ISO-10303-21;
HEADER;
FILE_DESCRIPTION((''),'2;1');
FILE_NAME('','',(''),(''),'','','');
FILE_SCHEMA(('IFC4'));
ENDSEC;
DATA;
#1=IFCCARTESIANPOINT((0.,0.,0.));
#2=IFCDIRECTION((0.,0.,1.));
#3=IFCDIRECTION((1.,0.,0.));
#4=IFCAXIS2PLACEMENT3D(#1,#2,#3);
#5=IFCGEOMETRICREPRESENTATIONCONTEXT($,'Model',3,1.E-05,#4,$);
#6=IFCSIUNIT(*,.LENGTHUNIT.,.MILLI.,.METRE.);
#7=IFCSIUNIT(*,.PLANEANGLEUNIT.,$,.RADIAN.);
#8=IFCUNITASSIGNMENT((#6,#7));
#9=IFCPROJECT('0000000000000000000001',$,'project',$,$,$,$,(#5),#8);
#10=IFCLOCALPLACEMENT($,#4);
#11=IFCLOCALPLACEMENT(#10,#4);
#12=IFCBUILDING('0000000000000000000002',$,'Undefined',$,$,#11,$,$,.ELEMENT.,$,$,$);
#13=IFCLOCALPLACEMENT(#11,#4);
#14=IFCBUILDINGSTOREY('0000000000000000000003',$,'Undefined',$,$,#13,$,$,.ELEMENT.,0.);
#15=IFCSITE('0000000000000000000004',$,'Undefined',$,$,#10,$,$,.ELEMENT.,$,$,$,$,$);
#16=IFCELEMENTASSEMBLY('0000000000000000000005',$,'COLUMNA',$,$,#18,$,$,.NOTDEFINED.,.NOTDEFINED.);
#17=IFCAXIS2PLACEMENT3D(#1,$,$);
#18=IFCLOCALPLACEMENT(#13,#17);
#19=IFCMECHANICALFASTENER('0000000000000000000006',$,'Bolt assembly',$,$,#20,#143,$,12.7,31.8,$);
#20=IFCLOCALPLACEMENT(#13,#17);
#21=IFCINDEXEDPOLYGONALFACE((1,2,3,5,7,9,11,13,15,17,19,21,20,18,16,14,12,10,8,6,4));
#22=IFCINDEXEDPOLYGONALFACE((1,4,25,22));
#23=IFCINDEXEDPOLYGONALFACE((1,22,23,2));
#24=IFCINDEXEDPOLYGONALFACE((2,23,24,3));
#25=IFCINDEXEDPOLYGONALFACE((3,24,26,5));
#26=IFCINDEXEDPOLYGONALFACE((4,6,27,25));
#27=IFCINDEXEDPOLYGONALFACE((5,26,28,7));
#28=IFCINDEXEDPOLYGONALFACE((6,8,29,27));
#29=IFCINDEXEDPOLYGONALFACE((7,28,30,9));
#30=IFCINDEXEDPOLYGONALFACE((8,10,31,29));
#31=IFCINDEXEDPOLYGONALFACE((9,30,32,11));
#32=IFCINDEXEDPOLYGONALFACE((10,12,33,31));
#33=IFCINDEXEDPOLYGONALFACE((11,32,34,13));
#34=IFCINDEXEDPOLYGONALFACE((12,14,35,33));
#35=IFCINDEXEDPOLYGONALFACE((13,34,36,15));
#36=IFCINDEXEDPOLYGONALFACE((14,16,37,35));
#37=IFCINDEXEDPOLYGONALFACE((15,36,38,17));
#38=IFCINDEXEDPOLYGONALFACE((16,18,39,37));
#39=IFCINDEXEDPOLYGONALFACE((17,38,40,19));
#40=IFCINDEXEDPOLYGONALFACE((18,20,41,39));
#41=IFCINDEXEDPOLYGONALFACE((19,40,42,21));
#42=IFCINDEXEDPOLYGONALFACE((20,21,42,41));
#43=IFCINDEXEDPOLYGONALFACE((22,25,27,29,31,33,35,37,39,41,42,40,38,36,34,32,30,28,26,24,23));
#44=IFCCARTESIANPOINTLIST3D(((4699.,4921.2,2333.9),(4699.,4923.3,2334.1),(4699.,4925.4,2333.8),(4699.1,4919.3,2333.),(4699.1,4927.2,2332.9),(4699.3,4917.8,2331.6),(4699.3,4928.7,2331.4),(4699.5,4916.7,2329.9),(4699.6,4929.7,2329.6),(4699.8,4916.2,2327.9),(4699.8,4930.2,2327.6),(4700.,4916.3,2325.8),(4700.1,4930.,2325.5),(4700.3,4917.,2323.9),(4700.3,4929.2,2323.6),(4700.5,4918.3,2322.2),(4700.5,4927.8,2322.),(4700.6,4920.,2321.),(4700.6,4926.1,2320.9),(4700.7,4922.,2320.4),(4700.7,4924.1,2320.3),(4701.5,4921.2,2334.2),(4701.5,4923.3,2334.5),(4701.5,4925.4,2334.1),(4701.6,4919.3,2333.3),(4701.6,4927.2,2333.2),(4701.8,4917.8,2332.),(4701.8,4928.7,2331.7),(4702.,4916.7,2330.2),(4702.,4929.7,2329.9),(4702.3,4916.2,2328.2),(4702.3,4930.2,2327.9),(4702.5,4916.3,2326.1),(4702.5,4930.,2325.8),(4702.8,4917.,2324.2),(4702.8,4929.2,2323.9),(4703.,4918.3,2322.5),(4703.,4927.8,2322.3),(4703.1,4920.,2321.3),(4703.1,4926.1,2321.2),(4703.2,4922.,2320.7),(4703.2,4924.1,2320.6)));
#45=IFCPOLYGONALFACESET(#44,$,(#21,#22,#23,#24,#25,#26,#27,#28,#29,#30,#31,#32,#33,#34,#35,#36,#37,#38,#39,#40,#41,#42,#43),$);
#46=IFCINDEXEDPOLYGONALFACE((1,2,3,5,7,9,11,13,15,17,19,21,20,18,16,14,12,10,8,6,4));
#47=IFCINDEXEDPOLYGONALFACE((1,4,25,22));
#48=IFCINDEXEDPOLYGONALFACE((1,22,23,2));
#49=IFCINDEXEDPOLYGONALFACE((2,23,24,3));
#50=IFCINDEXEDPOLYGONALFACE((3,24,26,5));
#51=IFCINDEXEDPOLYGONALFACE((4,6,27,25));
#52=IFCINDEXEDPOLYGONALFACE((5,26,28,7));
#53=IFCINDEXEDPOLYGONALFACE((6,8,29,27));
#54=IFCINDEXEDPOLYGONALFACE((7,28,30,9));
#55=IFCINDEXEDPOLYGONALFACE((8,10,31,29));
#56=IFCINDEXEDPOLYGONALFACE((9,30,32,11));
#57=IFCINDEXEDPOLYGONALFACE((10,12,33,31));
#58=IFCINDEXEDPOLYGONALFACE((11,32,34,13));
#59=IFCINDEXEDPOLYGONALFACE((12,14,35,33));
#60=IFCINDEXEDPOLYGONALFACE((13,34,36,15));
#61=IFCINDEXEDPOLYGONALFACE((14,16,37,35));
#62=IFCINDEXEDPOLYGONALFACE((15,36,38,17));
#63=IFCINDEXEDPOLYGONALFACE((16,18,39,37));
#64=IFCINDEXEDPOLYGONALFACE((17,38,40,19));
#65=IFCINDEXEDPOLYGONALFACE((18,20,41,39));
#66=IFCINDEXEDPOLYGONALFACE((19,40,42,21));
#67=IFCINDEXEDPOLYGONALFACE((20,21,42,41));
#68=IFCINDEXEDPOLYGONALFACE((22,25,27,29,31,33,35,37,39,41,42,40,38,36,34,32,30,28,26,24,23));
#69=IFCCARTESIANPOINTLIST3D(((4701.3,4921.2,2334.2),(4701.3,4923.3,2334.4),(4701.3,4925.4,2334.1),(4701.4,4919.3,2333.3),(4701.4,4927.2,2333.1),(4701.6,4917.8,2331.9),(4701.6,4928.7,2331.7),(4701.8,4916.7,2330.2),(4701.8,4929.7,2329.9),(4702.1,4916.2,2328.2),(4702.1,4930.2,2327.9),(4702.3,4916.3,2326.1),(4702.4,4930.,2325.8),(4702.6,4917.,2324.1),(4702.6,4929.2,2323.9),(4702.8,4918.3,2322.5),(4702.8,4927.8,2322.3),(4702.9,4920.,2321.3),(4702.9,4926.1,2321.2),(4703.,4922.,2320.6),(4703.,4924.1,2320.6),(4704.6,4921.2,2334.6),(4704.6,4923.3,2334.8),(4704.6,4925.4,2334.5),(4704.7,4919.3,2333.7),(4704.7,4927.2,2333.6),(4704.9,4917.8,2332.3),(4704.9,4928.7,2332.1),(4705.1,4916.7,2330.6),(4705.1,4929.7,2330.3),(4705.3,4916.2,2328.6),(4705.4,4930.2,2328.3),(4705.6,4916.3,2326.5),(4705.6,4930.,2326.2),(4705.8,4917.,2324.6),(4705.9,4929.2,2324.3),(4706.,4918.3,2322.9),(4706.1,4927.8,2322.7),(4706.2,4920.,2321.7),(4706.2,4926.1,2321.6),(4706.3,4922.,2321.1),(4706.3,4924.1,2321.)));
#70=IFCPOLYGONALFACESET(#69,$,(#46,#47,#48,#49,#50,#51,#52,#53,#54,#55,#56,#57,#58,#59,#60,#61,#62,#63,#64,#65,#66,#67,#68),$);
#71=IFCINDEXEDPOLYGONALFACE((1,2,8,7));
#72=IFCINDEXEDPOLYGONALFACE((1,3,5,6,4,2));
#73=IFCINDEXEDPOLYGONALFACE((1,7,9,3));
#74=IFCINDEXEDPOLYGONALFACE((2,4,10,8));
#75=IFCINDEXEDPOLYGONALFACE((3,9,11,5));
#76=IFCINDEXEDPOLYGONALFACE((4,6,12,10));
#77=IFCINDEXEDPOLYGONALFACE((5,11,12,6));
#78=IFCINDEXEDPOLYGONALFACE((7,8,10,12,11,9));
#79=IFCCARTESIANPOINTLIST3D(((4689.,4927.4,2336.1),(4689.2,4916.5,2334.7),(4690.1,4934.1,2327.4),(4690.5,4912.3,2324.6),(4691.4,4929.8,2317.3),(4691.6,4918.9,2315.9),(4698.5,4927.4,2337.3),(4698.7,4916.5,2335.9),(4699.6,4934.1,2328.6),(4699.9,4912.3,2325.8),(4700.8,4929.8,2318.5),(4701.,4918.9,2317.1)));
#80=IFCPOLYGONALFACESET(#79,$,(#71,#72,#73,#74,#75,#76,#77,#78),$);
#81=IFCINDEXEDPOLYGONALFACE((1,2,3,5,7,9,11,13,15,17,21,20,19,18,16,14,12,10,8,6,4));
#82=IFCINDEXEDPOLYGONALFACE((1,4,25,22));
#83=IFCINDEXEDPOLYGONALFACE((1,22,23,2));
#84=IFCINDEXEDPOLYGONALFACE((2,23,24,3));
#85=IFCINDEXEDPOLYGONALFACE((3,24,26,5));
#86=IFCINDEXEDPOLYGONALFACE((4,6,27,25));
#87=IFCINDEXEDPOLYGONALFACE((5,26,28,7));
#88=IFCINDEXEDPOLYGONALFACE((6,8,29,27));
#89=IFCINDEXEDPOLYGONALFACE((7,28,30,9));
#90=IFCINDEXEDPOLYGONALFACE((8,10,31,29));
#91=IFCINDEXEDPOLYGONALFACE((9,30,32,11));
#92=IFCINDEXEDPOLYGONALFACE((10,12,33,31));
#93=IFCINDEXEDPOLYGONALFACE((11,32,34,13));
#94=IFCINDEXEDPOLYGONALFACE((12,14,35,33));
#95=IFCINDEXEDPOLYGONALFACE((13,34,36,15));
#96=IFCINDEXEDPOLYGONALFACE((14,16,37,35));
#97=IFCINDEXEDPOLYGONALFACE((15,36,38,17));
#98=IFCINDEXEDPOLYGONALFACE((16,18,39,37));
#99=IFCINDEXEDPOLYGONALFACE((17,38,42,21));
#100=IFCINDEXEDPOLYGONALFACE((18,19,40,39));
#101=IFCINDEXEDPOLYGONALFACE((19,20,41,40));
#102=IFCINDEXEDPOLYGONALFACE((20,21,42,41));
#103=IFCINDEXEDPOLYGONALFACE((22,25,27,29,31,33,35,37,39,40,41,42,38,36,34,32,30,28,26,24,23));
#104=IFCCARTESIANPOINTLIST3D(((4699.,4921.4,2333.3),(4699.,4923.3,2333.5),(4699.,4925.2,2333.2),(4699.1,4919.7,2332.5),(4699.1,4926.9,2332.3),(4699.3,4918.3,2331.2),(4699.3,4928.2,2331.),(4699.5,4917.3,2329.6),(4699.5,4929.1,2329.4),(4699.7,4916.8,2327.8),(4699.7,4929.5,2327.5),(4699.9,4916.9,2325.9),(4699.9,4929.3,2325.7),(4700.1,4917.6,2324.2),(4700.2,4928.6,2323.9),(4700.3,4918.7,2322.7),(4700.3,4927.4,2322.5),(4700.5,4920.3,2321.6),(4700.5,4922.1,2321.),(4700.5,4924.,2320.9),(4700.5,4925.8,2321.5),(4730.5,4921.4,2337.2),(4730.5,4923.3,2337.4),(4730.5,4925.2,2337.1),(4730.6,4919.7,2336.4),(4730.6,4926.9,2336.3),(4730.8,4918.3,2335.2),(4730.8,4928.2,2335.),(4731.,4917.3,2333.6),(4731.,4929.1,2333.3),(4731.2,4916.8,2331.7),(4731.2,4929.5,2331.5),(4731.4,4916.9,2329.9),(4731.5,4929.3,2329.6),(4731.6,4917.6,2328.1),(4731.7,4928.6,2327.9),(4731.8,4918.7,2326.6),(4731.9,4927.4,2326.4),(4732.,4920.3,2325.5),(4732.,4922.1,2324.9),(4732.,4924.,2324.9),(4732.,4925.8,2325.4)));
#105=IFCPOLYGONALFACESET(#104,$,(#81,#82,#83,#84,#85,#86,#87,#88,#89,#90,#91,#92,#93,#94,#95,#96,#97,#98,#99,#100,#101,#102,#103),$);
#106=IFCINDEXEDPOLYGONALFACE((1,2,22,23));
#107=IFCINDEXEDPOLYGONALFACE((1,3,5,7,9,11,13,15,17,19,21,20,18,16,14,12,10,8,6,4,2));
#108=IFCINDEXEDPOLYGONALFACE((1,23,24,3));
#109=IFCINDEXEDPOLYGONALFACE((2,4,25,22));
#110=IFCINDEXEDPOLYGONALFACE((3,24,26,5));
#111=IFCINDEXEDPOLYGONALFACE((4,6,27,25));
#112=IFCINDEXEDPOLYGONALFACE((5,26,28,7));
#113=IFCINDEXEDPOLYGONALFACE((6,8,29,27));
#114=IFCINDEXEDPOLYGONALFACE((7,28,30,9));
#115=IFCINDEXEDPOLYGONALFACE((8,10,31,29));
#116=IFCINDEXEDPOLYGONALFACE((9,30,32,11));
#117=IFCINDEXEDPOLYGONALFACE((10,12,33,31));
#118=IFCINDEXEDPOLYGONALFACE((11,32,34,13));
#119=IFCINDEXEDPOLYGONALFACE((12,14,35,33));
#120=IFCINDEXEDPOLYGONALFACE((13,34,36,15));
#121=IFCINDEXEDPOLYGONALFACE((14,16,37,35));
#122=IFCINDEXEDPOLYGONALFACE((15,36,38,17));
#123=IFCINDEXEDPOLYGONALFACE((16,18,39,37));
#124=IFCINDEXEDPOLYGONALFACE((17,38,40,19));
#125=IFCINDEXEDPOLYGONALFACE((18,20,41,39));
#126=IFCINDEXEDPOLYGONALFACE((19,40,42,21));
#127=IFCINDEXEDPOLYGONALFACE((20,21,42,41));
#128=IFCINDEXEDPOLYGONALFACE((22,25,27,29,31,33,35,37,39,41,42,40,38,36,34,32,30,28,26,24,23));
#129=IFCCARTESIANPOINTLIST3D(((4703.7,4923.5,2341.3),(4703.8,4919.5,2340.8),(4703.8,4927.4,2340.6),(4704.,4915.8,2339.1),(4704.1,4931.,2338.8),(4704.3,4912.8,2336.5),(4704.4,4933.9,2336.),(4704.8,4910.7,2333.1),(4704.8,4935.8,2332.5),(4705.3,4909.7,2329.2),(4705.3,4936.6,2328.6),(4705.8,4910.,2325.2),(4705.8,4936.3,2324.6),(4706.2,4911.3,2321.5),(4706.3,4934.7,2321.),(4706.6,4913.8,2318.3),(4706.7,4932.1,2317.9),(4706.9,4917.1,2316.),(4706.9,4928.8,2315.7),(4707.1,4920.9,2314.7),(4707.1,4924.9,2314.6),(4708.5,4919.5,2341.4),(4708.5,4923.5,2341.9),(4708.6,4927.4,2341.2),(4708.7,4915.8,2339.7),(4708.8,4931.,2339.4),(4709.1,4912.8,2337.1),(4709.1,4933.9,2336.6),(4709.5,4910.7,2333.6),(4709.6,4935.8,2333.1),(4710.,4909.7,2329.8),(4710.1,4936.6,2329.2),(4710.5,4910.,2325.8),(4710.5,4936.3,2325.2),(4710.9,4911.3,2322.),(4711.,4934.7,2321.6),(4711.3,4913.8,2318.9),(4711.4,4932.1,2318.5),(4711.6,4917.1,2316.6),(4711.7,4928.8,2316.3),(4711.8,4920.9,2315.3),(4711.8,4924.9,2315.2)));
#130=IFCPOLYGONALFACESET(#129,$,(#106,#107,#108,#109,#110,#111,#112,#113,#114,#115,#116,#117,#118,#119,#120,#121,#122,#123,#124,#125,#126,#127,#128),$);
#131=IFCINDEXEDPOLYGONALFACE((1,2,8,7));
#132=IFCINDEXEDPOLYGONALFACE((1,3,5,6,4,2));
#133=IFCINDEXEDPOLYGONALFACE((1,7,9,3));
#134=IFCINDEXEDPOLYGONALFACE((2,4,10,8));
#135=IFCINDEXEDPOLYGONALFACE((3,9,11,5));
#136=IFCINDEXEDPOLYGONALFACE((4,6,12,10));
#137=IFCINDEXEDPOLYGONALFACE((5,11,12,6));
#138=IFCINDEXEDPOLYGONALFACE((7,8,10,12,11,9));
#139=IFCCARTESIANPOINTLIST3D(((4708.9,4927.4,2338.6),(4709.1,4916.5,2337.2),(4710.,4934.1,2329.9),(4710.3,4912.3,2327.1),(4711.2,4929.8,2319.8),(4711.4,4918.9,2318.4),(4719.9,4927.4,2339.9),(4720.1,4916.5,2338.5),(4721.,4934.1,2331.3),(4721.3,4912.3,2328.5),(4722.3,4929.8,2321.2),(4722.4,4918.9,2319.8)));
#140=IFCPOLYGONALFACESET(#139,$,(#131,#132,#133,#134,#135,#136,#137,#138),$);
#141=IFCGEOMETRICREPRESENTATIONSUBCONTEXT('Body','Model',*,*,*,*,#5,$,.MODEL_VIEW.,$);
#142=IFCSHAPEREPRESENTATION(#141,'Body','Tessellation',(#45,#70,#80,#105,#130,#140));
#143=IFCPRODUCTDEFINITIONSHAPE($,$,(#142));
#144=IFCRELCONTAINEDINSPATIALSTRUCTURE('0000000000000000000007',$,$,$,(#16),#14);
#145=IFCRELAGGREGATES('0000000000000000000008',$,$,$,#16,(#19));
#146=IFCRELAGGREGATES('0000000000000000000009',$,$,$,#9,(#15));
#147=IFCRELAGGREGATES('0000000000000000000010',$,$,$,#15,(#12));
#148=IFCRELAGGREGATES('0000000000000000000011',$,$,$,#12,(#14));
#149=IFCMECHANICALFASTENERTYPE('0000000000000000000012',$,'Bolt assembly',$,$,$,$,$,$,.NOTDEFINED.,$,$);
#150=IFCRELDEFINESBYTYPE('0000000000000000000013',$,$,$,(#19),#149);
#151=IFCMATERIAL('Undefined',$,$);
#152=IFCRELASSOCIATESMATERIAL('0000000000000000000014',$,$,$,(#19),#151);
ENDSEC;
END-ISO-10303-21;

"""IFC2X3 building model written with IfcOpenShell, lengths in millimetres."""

from ifc_helpers import new_model, si_unit, frame, origin_with_axes, origin_2d_with_axis, place, context, subcontext, project, spatial, polyline, circle, outline, extrude, source, transform, mapped, material, type_object, element, aggregate, save


model = new_model("IFC2X3")

# Units and contexts
model_context = context("Model", 3, precision=1e-05, world=origin_with_axes())
body_context = subcontext(model_context, "Body", "Model", "MODEL_VIEW")
ifc_project = project(units=[si_unit("LENGTHUNIT", "METRE", prefix="MILLI"), si_unit("PLANEANGLEUNIT", "RADIAN")], contexts=[model_context])

# Site, building, storey
site_placement = place(None, origin_with_axes())
site = spatial("IfcSite", under=ifc_project, at=site_placement, Name="Undefined", CompositionType="ELEMENT")
building_placement = place(site_placement, origin_with_axes())
building = spatial("IfcBuilding", under=site, at=building_placement, Name="Undefined", CompositionType="ELEMENT")
storey_placement = place(building_placement, origin_with_axes())
storey = spatial("IfcBuildingStorey", under=building, at=storey_placement, Name="Undefined", CompositionType="ELEMENT", Elevation=0.0)

# Element assembly
assembly_1_placement = place(storey_placement, origin_with_axes())
assembly_1 = element("IfcElementAssembly", 1, at=assembly_1_placement, inside=storey, Name="COLUMNA", AssemblyPlace="NOTDEFINED", PredefinedType="NOTDEFINED")

# Shared definitions
ifc_material_1 = material(Name="Undefined")
mechanical_fastener_type = type_object("IfcMechanicalFastenerType", Name="Bolt assembly")

# Mechanical fastener
shared_shape_1 = source(origin_with_axes(), body_context, "Body", "SweptSolid", [
    extrude(circle(Radius=7.0, at=origin_2d_with_axis()), frame((0.0, -2.4, 0.0), z_axis=(0.0, 1.0, 0.0), x_axis=(1.0, 0.0, 0.0)), (0.0, 0.0, 1.0), 2.5),
    extrude(circle(Radius=7.0, at=origin_2d_with_axis()), frame((0.0, -0.1, 0.0), z_axis=(0.0, 1.0, 0.0), x_axis=(1.0, 0.0, 0.0)), (0.0, 0.0, 1.0), 3.3),
    extrude(outline(polyline([(9.5, -5.5), (9.5, 5.5), (0.0, 11.0), (-9.5, 5.5), (-9.5, -5.5), (0.0, -11.0), (9.5, -5.5)])), frame((0.0, -12.0, 0.0), z_axis=(0.0, 1.0, 0.0), x_axis=(1.0, 0.0, 0.0)), (0.0, 0.0, 1.0), 9.5),
    extrude(circle(Radius=6.3, at=origin_2d_with_axis()), frame((0.0, -2.5, 0.0), z_axis=(0.0, 1.0, 0.0), x_axis=(1.0, 0.0, 0.0)), (0.0, 0.0, 1.0), 31.8),
    extrude(circle(Radius=13.5, at=origin_2d_with_axis()), frame((0.0, 3.2, 0.0), z_axis=(0.0, 1.0, 0.0), x_axis=(1.0, 0.0, 0.0)), (0.0, 0.0, 1.0), 4.8),
    extrude(outline(polyline([(9.5, -5.5), (9.5, 5.5), (0.0, 11.0), (-9.5, 5.5), (-9.5, -5.5), (0.0, -11.0), (9.5, -5.5)])), frame((0.0, 8.0, 0.0), z_axis=(0.0, 1.0, 0.0), x_axis=(1.0, 0.0, 0.0)), (0.0, 0.0, 1.0), 11.1),
])
mechanical_fastener_1_placement = place(assembly_1_placement, frame((4702.2, 4923.2, 2327.5), z_axis=(0.098611, 0.606774, -0.788734), x_axis=(-0.075276, 0.794875, 0.602086)))
mechanical_fastener_1 = element("IfcMechanicalFastener", 2, at=mechanical_fastener_1_placement, type_object=mechanical_fastener_type, material=ifc_material_1, Name="Bolt assembly", NominalDiameter=12.7, NominalLength=31.8, context=body_context, shape_type="MappedRepresentation", body=[
    mapped(shared_shape_1, transform((0.0, 0.0, 0.0))),
])
aggregate(assembly_1, [mechanical_fastener_1])

save(model, "model.ifc")
